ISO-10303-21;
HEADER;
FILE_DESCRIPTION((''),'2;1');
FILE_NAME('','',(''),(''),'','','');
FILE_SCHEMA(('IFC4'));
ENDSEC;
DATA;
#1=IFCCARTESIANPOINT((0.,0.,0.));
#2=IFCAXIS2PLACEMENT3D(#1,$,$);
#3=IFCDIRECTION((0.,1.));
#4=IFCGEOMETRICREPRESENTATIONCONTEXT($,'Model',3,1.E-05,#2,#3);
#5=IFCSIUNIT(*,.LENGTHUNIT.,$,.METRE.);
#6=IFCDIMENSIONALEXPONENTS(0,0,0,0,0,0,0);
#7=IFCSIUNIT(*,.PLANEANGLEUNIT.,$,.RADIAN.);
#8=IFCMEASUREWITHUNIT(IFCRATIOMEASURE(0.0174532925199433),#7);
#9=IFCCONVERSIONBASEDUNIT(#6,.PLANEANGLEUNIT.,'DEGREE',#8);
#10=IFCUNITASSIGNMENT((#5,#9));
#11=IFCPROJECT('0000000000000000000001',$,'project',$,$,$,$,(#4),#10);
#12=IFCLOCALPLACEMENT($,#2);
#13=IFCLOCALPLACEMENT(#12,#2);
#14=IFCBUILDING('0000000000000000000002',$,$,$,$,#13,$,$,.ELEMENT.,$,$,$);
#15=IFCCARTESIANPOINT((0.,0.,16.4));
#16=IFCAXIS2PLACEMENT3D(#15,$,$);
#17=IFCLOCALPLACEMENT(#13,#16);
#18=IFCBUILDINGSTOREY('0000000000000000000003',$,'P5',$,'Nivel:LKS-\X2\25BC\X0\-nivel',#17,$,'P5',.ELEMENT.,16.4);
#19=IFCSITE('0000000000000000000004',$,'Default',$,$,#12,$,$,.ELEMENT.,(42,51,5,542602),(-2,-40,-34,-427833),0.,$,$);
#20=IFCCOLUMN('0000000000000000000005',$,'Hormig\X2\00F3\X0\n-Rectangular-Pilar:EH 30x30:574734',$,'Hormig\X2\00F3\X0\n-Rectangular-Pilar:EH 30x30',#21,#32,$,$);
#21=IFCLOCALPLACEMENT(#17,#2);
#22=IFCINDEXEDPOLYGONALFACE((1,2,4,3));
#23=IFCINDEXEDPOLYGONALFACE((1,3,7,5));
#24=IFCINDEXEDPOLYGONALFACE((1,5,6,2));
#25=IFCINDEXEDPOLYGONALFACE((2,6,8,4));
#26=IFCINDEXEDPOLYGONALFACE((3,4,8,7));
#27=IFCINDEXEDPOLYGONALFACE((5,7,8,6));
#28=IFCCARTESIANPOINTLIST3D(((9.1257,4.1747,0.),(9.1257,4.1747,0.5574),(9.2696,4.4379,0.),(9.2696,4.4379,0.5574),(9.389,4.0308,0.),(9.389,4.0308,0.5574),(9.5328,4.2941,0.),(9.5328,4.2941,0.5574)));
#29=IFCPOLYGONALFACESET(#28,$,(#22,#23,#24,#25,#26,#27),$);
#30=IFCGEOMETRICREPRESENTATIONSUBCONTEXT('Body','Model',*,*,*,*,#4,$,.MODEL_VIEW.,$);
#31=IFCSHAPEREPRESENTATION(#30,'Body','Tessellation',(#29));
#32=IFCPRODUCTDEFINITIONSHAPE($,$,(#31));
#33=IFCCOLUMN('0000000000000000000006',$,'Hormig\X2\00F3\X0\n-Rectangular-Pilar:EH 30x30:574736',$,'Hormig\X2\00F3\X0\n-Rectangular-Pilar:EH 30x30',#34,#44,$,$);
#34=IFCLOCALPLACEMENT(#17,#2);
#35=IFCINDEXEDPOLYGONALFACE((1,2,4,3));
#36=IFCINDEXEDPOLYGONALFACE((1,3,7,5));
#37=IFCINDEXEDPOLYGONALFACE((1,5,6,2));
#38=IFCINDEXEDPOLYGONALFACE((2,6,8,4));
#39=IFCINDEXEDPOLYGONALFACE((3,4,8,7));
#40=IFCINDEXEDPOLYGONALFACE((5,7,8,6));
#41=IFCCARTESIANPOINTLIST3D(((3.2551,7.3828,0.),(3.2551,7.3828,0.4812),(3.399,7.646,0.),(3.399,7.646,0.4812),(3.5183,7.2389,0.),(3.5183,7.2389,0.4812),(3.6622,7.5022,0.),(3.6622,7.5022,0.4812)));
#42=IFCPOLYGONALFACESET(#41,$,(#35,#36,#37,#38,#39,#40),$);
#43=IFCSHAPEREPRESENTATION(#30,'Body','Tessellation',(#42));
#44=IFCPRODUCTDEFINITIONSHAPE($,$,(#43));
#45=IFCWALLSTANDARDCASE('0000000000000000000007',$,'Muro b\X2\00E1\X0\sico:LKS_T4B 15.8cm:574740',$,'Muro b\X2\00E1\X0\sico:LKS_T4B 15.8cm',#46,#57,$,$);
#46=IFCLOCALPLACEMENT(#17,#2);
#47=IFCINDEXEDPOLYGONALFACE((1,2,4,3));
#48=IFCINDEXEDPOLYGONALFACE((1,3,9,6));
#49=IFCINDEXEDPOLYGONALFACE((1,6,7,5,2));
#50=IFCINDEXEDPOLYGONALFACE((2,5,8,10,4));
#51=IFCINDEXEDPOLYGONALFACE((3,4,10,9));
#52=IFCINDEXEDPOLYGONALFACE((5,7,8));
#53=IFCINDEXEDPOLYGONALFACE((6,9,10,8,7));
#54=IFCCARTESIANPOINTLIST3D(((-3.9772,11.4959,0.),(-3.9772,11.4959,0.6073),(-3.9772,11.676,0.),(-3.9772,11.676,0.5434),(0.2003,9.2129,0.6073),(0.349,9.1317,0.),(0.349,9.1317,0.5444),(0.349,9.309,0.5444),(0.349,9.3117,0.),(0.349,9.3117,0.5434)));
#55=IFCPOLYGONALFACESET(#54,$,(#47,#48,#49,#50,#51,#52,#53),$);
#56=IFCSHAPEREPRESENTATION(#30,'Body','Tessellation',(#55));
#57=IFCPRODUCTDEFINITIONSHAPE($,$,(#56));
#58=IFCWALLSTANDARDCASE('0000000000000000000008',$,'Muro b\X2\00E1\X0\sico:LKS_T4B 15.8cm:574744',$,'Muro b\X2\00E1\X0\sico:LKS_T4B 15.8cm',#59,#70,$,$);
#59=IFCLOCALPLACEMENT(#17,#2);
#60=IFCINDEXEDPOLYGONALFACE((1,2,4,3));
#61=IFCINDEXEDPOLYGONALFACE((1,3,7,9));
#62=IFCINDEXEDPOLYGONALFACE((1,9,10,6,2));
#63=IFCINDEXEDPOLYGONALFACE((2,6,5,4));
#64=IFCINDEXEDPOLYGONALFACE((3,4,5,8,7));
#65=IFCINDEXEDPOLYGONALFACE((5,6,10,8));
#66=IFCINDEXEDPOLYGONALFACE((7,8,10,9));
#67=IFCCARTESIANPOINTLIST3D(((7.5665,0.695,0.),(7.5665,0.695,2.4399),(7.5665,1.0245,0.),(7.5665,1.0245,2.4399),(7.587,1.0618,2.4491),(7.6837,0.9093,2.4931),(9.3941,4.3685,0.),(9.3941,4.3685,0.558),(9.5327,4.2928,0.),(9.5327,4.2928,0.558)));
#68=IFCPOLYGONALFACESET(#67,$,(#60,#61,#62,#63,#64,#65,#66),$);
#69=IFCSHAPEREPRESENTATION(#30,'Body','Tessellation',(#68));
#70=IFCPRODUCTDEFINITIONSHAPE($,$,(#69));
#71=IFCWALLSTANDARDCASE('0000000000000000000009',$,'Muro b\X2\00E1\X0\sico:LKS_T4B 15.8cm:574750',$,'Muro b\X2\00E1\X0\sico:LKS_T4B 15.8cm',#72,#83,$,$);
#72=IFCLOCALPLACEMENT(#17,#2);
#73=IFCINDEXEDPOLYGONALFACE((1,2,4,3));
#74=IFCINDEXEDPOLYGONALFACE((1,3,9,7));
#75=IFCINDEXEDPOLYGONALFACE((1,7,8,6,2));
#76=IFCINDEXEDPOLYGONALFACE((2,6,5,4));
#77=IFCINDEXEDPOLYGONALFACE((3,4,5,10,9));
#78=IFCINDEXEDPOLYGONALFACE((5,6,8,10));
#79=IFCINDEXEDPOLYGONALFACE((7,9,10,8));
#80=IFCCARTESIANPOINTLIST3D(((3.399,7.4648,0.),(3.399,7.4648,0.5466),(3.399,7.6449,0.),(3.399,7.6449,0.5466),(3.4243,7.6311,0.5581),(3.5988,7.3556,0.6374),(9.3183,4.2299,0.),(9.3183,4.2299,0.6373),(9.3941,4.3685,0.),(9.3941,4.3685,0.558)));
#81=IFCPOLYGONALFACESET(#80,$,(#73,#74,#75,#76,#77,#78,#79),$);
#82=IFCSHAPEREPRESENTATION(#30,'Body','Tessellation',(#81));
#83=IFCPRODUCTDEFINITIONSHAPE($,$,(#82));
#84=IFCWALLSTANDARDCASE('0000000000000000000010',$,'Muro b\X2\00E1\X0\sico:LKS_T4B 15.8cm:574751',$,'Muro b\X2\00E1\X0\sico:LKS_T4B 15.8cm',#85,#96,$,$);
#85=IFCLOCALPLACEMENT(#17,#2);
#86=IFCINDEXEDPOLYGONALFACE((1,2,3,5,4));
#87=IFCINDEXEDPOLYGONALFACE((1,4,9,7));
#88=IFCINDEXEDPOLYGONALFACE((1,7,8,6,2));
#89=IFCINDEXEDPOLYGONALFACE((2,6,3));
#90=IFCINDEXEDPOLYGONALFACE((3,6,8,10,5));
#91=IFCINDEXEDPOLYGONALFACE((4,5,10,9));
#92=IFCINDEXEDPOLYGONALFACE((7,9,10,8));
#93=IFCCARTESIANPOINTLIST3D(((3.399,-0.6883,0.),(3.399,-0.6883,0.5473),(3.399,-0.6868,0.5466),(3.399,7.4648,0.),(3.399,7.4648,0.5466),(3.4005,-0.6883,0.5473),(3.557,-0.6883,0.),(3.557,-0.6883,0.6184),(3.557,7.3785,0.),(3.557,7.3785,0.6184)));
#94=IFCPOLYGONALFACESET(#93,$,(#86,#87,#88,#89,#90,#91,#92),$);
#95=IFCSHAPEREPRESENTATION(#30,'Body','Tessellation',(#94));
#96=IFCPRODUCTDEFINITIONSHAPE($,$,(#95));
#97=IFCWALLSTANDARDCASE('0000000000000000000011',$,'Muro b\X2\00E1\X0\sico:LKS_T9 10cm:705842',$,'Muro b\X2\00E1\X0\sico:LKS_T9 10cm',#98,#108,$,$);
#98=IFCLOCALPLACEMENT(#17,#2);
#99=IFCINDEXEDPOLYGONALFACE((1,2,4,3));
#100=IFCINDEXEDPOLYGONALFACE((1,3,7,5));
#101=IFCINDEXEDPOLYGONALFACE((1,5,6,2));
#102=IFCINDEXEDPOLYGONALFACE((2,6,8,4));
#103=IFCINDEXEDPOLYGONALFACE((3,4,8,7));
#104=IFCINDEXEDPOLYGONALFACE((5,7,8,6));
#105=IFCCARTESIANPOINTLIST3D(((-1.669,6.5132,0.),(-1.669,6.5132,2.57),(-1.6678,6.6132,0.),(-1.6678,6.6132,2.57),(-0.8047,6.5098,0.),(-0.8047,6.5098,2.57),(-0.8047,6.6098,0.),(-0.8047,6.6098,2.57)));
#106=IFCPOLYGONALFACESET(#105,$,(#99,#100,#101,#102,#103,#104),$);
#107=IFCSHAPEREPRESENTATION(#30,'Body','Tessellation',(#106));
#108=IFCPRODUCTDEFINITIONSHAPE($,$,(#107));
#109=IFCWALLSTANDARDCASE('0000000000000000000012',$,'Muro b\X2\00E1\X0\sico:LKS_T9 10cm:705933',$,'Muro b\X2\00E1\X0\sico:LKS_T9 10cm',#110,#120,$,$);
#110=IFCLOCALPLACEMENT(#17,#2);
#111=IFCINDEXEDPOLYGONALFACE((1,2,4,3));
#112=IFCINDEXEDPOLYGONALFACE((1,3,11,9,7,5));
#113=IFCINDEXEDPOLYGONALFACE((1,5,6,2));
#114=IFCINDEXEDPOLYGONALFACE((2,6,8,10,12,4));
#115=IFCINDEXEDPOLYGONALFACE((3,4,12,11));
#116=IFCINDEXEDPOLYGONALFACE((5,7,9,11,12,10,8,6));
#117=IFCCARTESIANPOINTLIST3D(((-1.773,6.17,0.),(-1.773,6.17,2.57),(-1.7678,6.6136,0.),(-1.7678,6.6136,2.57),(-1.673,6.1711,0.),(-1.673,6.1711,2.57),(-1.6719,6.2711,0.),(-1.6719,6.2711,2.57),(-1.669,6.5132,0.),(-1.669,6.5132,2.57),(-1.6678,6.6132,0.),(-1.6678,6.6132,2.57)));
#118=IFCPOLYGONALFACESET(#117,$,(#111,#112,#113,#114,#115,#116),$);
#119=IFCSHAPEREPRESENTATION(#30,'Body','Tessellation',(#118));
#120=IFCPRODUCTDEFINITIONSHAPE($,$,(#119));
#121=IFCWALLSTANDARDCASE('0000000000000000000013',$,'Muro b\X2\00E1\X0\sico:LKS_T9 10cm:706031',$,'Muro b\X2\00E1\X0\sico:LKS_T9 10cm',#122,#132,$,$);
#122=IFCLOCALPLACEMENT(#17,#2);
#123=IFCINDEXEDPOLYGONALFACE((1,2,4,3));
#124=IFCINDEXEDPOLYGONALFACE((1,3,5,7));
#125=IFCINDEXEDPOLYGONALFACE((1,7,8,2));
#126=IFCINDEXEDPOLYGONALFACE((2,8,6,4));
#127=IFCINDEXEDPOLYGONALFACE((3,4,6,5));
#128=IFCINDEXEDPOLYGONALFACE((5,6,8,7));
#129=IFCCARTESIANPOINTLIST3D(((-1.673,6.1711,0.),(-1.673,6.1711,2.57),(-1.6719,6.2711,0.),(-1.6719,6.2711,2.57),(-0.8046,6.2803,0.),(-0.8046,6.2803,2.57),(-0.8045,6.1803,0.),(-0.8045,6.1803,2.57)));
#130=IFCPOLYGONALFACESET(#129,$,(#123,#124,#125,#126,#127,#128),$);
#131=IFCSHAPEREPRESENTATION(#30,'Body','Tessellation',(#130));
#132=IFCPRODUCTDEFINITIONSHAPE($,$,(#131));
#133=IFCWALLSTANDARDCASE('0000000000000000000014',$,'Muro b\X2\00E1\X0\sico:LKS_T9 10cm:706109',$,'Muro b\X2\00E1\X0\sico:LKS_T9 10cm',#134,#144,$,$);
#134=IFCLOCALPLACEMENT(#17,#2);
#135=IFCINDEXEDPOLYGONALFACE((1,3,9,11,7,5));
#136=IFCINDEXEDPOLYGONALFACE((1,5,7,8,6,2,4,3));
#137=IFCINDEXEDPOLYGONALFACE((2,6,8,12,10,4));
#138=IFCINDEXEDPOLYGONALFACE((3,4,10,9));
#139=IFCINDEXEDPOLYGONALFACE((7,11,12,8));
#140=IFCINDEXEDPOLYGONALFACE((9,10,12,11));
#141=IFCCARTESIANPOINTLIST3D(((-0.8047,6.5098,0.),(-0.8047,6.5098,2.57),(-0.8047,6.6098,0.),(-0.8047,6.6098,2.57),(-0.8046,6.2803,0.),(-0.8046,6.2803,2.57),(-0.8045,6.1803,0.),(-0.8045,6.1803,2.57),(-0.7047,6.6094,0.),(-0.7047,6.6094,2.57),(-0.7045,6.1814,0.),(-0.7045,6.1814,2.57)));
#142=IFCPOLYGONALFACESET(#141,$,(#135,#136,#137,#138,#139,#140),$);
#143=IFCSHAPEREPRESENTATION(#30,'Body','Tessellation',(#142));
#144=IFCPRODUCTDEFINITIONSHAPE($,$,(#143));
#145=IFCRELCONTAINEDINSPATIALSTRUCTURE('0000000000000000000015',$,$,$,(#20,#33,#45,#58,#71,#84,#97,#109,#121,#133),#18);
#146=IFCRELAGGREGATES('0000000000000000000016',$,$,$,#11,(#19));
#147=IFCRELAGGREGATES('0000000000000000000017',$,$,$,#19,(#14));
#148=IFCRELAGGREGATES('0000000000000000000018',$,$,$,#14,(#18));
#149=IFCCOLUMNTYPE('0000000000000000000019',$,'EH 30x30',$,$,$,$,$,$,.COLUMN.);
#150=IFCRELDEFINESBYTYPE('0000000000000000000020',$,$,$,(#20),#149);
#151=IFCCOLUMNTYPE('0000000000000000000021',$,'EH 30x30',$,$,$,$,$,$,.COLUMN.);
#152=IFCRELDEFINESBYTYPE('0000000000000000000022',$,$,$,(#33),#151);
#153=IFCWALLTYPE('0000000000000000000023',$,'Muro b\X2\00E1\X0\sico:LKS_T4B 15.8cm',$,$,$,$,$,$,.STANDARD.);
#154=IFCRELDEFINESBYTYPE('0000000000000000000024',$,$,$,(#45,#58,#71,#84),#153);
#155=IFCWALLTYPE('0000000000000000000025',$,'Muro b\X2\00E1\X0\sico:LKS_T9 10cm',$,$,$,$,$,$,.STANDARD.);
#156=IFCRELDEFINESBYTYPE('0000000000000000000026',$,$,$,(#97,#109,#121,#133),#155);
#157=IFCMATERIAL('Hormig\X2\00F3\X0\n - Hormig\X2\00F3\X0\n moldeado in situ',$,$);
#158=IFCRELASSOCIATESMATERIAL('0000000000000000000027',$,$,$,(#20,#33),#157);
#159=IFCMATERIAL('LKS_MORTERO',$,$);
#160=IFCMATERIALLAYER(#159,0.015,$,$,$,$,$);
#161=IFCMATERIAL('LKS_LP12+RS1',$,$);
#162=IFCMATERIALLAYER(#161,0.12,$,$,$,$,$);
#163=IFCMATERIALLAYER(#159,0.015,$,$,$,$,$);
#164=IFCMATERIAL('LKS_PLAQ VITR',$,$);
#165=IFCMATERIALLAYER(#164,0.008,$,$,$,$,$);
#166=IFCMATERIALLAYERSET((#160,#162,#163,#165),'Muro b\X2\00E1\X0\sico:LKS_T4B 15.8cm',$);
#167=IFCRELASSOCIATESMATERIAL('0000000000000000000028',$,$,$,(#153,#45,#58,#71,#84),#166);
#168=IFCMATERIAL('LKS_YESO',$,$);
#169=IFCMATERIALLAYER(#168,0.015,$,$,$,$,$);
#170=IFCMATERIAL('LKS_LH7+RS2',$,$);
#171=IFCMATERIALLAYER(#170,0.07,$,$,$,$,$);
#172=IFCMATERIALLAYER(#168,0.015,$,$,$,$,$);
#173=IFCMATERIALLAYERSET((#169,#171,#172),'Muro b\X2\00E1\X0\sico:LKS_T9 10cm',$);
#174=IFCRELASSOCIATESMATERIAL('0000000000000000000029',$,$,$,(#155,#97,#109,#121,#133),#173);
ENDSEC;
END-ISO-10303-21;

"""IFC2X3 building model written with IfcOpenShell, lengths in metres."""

from ifc_helpers import new_model, entity, si_unit, converted_unit, direction, frame, frame_2d, origin, place, context, subcontext, project, spatial, polyline, rectangle, outline, extrude, clip, bounded_halfspace, source, transform, mapped, material, layer, layer_set, layer_usage, type_object, type_shapes, element, save


model = new_model("IFC2X3")

# Units and contexts
model_context = context("Model", 3, precision=1e-05, world=origin(), true_north=direction((0.0, 1.0)))
body_context = subcontext(model_context, "Body", "Model", "MODEL_VIEW")
ifc_project = project(units=[si_unit("LENGTHUNIT", "METRE"), converted_unit("PLANEANGLEUNIT", "DEGREE", entity("IfcRatioMeasure", 0.0174532925199433), si_unit("PLANEANGLEUNIT", "RADIAN"), dimensions=[0, 0, 0, 0, 0, 0, 0])], contexts=[model_context])

# Site, building, storey
site_placement = place(None, origin())
site = spatial("IfcSite", under=ifc_project, at=site_placement, Name="Default", CompositionType="ELEMENT", RefLatitude=(42, 51, 5, 542602), RefLongitude=(-2, -40, -34, -427833), RefElevation=0.0)
building_placement = place(site_placement, origin())
building = spatial("IfcBuilding", under=site, at=building_placement, CompositionType="ELEMENT")
storey_placement = place(building_placement, frame((0.0, 0.0, 16.4)))
storey = spatial("IfcBuildingStorey", under=building, at=storey_placement, Name="P5", ObjectType="Nivel:LKS-▼-nivel", LongName="P5", CompositionType="ELEMENT", Elevation=16.4)

# Columns
ifc_material_1 = material(Name="Hormigón - Hormigón moldeado in situ")
column_type_1 = type_object("IfcColumnType", Name="EH 30x30", PredefinedType="COLUMN")
shared_shape_1 = source(origin(), body_context, "Body", "SweptSolid", [
    extrude(rectangle(XDim=0.3, YDim=0.3, at=frame_2d((0.0, 0.0), x_axis=(1.0, 0.0))), frame((9.3293, 4.2344, 16.4), z_axis=(0.0, 0.0, 1.0), x_axis=(0.479561, 0.877509, 0.0)), (0.0, 0.0, 1.0), 0.5574),
])
type_shapes(column_type_1, [shared_shape_1])
column_1_placement = place(storey_placement, frame((0.0, 0.0, -16.4)))
element("IfcColumn", 1, at=column_1_placement, inside=storey, type_object=column_type_1, material=ifc_material_1, Name="Hormigón-Rectangular-Pilar:EH 30x30:574734", ObjectType="Hormigón-Rectangular-Pilar:EH 30x30", context=body_context, shape_type="MappedRepresentation", body=[
    mapped(shared_shape_1, transform((0.0, 0.0, 0.0), scale=1.0)),
])
column_type_2 = type_object("IfcColumnType", Name="EH 30x30", PredefinedType="COLUMN")
shared_shape_2 = source(origin(), body_context, "Body", "SweptSolid", [
    extrude(rectangle(XDim=0.3, YDim=0.3, at=frame_2d((0.0, 0.0), x_axis=(1.0, 0.0))), frame((3.4587, 7.4425, 16.4), z_axis=(0.0, 0.0, 1.0), x_axis=(0.479561, 0.877509, 0.0)), (0.0, 0.0, 1.0), 0.4812),
])
type_shapes(column_type_2, [shared_shape_2])
column_2_placement = place(storey_placement, frame((0.0, 0.0, -16.4)))
element("IfcColumn", 2, at=column_2_placement, inside=storey, type_object=column_type_2, material=ifc_material_1, Name="Hormigón-Rectangular-Pilar:EH 30x30:574736", ObjectType="Hormigón-Rectangular-Pilar:EH 30x30", context=body_context, shape_type="MappedRepresentation", body=[
    mapped(shared_shape_2, transform((0.0, 0.0, 0.0), scale=1.0)),
])

# Walls
ifc_material_2 = material(Name="LKS_MORTERO")
ifc_layer_1 = layer(ifc_material_2, 0.015)
ifc_material_3 = material(Name="LKS_LP12+RS1")
ifc_layer_2 = layer(ifc_material_3, 0.12)
ifc_layer_3 = layer(ifc_material_2, 0.015)
ifc_material_4 = material(Name="LKS_PLAQ VITR")
ifc_layer_4 = layer(ifc_material_4, 0.008)
ifc_layer_set_1 = layer_set([ifc_layer_1, ifc_layer_2, ifc_layer_3, ifc_layer_4], Name="Muro básico:LKS_T4B 15.8cm")
ifc_layer_usage_1 = layer_usage(ifc_layer_set_1, "AXIS2", "POSITIVE", -0.079)
wall_type_1 = type_object("IfcWallType", Name="Muro básico:LKS_T4B 15.8cm", PredefinedType="STANDARD", material=ifc_layer_set_1)
wall_1_placement = place(storey_placement, frame((0.3868, 9.201, 0.0), z_axis=(0.0, 0.0, 1.0), x_axis=(-0.877509, 0.479561, 0.0)))
element("IfcWallStandardCase", 3, at=wall_1_placement, inside=storey, type_object=wall_type_1, material=ifc_layer_usage_1, Name="Muro básico:LKS_T4B 15.8cm:574740", ObjectType="Muro básico:LKS_T4B 15.8cm", context=body_context, shape_type="Clipping", body=[
    clip(clip(extrude(outline(polyline([(5.0163, -0.079), (4.93, 0.079), (4.8683, 0.079), (4.7499, 0.079), (4.6451, 0.079), (0.2712, 0.079), (0.1801, 0.079), (0.0, 0.079), (0.0863, -0.079), (0.3576, -0.079), (5.0163, -0.079)])), origin(), (0.0, 0.0, 1.0), 0.6073), bounded_halfspace(frame((0.0863, -0.079, 0.5434), z_axis=(0.0, -0.374607, 0.927184), x_axis=(1.0, 0.0, 0.0)), False, frame((0.0863, -0.079, 0.5434)), polyline([(0.0, 0.0), (4.93, 0.0), (4.8437, 0.158), (4.6636, 0.158), (0.0937, 0.158), (0.083, 0.158), (-0.0013, 0.0024), (0.0, 0.0)]))), bounded_halfspace(frame((0.1694, 0.079, 0.6073), z_axis=(-0.341802, -0.186796, 0.921021), x_axis=(0.479561, -0.877509, 0.0)), False, frame((0.1694, 0.079, 0.6073)), polyline([(0.0, 0.0), (-0.1694, 0.0), (-0.0843, -0.1556), (0.0, 0.0)]))),
])
ifc_layer_usage_2 = layer_usage(ifc_layer_set_1, "AXIS2", "POSITIVE", -0.079)
wall_2_placement = place(storey_placement, frame((7.4972, 0.7329, 0.0), z_axis=(0.0, 0.0, 1.0), x_axis=(0.479561, 0.877509, 0.0)))
element("IfcWallStandardCase", 4, at=wall_2_placement, inside=storey, type_object=wall_type_1, material=ifc_layer_usage_2, Name="Muro básico:LKS_T4B 15.8cm:574744", ObjectType="Muro básico:LKS_T4B 15.8cm", context=body_context, shape_type="Clipping", body=[
    clip(clip(extrude(outline(polyline([(4.1, -0.079), (4.1, -0.0784), (4.1, 0.079), (3.942, 0.079), (3.8012, 0.079), (0.2891, 0.079), (0.0, -0.079), (4.1, -0.079)])), origin(), (0.0, 0.0, 1.0), 2.4931), bounded_halfspace(frame((0.0, -0.079, 2.4399), z_axis=(-0.198349, 0.362942, 0.910456), x_axis=(-0.877509, -0.479561, 0.0)), False, frame((0.0, -0.079, 2.4399)), polyline([(0.0, 0.0), (0.2442, 0.0), (0.3317, 0.158), (0.2891, 0.158), (0.0, 0.0)]))), bounded_halfspace(frame((0.2442, -0.079, 2.4931), z_axis=(0.448539, -0.000012, 0.893763), x_axis=(0.000028, 1.0, 0.0)), False, frame((0.2442, -0.079, 2.4931)), polyline([(0.0, 0.0), (3.8558, 0.0), (3.8558, 0.158), (3.6978, 0.158), (0.0875, 0.158), (0.0, 0.0)]))),
])
ifc_layer_usage_3 = layer_usage(ifc_layer_set_1, "AXIS2", "POSITIVE", -0.079)
wall_3_placement = place(storey_placement, frame((9.3562, 4.2992, 0.0), z_axis=(0.0, 0.0, 1.0), x_axis=(-0.877509, 0.479561, 0.0)))
element("IfcWallStandardCase", 5, at=wall_3_placement, inside=storey, type_object=wall_type_1, material=ifc_layer_usage_3, Name="Muro básico:LKS_T4B 15.8cm:574750", ObjectType="Muro básico:LKS_T4B 15.8cm", context=body_context, shape_type="Clipping", body=[
    clip(clip(extrude(outline(polyline([(6.832, -0.079), (6.7457, 0.079), (6.5656, 0.079), (6.5325, 0.079), (0.1426, 0.079), (0.0, 0.079), (0.0, -0.079), (0.1426, -0.079), (6.5325, -0.079), (6.832, -0.079)])), origin(), (0.0, 0.0, 1.0), 0.6374), bounded_halfspace(frame((6.8031, -0.079, 0.5581), z_axis=(0.362942, 0.198349, 0.910456), x_axis=(-0.479561, 0.877509, 0.0)), False, frame((6.8031, -0.079, 0.5581)), polyline([(0.0, 0.0), (0.0289, 0.0), (-0.0575, 0.158), (-0.2375, 0.158), (-0.2852, 0.158), (0.0, 0.0)]))), bounded_halfspace(frame((0.0, -0.079, 0.558), z_axis=(-0.000012, -0.448539, 0.893763), x_axis=(1.0, -0.000028, 0.0)), False, frame((0.0, -0.079, 0.558)), polyline([(0.0, 0.0), (6.8031, 0.0), (6.5179, 0.158), (0.0, 0.158), (0.0, 0.0)]))),
])
ifc_layer_usage_4 = layer_usage(ifc_layer_set_1, "AXIS2", "POSITIVE", -0.079)
wall_4_placement = place(storey_placement, frame((3.478, 7.4648, 0.0), z_axis=(0.0, 0.0, 1.0), x_axis=(0.0, -1.0, 0.0)))
element("IfcWallStandardCase", 6, at=wall_4_placement, inside=storey, type_object=wall_type_1, material=ifc_layer_usage_4, Name="Muro básico:LKS_T4B 15.8cm:574751", ObjectType="Muro básico:LKS_T4B 15.8cm", context=body_context, shape_type="Clipping", body=[
    clip(clip(extrude(outline(polyline([(8.1531, -0.079), (8.1531, 0.079), (0.0863, 0.079), (0.0, -0.079), (0.1607, -0.079), (3.902, -0.079), (4.0444, -0.079), (4.4444, -0.079), (8.1531, -0.079)])), origin(), (0.0, 0.0, 1.0), 0.6184), bounded_halfspace(frame((0.0, -0.079, 0.5466), z_axis=(0.0, -0.413605, 0.910456), x_axis=(1.0, 0.0, 0.0)), False, frame((0.0, -0.079, 0.5466)), polyline([(0.0, 0.0), (8.1516, 0.0), (8.1531, 0.0015), (8.1531, 0.158), (0.0863, 0.158), (0.0, 0.0)]))), bounded_halfspace(frame((8.1516, -0.079, 0.5466), z_axis=(-0.415328, 0.0, 0.909672), x_axis=(0.0, -1.0, 0.0)), False, frame((8.1516, -0.079, 0.5466)), polyline([(0.0, 0.0), (0.0015, 0.0), (0.0015, 0.0015), (0.0, 0.0)]))),
])
ifc_material_5 = material(Name="LKS_YESO")
ifc_layer_5 = layer(ifc_material_5, 0.015)
ifc_material_6 = material(Name="LKS_LH7+RS2")
ifc_layer_6 = layer(ifc_material_6, 0.07)
ifc_layer_7 = layer(ifc_material_5, 0.015)
ifc_layer_set_2 = layer_set([ifc_layer_5, ifc_layer_6, ifc_layer_7], Name="Muro básico:LKS_T9 10cm")
ifc_layer_usage_5 = layer_usage(ifc_layer_set_2, "AXIS2", "POSITIVE", -0.05)
wall_type_2 = type_object("IfcWallType", Name="Muro básico:LKS_T9 10cm", PredefinedType="STANDARD", material=ifc_layer_set_2)
wall_5_placement = place(storey_placement, frame((-0.8045, 6.5598, 0.0), z_axis=(0.0, 0.0, 1.0), x_axis=(-0.999992, 0.003931, 0.0)))
element("IfcWallStandardCase", 7, at=wall_5_placement, inside=storey, type_object=wall_type_2, material=ifc_layer_usage_5, Name="Muro básico:LKS_T9 10cm:705842", ObjectType="Muro básico:LKS_T9 10cm", context=body_context, shape_type="SweptSolid", body=[
    extrude(outline(polyline([(0.8636, -0.05), (0.8644, 0.05), (0.0, 0.05), (0.0004, -0.05), (0.8636, -0.05)])), origin(), (0.0, 0.0, 1.0), 2.57),
])
ifc_layer_usage_6 = layer_usage(ifc_layer_set_2, "AXIS2", "POSITIVE", -0.05)
wall_6_placement = place(storey_placement, frame((-1.7178, 6.6138, 0.0), z_axis=(0.0, 0.0, 1.0), x_axis=(-0.011715, -0.999931, 0.0)))
element("IfcWallStandardCase", 8, at=wall_6_placement, inside=storey, type_object=wall_type_2, material=ifc_layer_usage_6, Name="Muro básico:LKS_T9 10cm:705933", ObjectType="Muro básico:LKS_T9 10cm", context=body_context, shape_type="SweptSolid", body=[
    extrude(outline(polyline([(0.4444, -0.05), (0.4422, 0.05), (0.3421, 0.05), (0.1, 0.05), (0.0, 0.05), (0.0008, -0.05), (0.4444, -0.05)])), origin(), (0.0, 0.0, 1.0), 2.57),
])
ifc_layer_usage_7 = layer_usage(ifc_layer_set_2, "AXIS2", "POSITIVE", -0.05)
wall_7_placement = place(storey_placement, frame((-1.6736, 6.2211, 0.0), z_axis=(0.0, 0.0, 1.0), x_axis=(0.999943, 0.010655, 0.0)))
element("IfcWallStandardCase", 9, at=wall_7_placement, inside=storey, type_object=wall_type_2, material=ifc_layer_usage_7, Name="Muro básico:LKS_T9 10cm:706031", ObjectType="Muro básico:LKS_T9 10cm", context=body_context, shape_type="SweptSolid", body=[
    extrude(outline(polyline([(0.8685, -0.05), (0.8696, 0.05), (0.0022, 0.05), (0.0, -0.05), (0.8685, -0.05)])), origin(), (0.0, 0.0, 1.0), 2.57),
])
ifc_layer_usage_8 = layer_usage(ifc_layer_set_2, "AXIS2", "POSITIVE", -0.05)
wall_8_placement = place(storey_placement, frame((-0.7545, 6.1803, 0.0), z_axis=(0.0, 0.0, 1.0), x_axis=(-0.000367, 1.0, 0.0)))
element("IfcWallStandardCase", 10, at=wall_8_placement, inside=storey, type_object=wall_type_2, material=ifc_layer_usage_8, Name="Muro básico:LKS_T9 10cm:706109", ObjectType="Muro básico:LKS_T9 10cm", context=body_context, shape_type="SweptSolid", body=[
    extrude(outline(polyline([(0.4291, -0.05), (0.4295, 0.05), (0.3295, 0.05), (0.1, 0.05), (0.0, 0.05), (0.001, -0.05), (0.4291, -0.05)])), origin(), (0.0, 0.0, 1.0), 2.57),
])

save(model, "model.ifc")
